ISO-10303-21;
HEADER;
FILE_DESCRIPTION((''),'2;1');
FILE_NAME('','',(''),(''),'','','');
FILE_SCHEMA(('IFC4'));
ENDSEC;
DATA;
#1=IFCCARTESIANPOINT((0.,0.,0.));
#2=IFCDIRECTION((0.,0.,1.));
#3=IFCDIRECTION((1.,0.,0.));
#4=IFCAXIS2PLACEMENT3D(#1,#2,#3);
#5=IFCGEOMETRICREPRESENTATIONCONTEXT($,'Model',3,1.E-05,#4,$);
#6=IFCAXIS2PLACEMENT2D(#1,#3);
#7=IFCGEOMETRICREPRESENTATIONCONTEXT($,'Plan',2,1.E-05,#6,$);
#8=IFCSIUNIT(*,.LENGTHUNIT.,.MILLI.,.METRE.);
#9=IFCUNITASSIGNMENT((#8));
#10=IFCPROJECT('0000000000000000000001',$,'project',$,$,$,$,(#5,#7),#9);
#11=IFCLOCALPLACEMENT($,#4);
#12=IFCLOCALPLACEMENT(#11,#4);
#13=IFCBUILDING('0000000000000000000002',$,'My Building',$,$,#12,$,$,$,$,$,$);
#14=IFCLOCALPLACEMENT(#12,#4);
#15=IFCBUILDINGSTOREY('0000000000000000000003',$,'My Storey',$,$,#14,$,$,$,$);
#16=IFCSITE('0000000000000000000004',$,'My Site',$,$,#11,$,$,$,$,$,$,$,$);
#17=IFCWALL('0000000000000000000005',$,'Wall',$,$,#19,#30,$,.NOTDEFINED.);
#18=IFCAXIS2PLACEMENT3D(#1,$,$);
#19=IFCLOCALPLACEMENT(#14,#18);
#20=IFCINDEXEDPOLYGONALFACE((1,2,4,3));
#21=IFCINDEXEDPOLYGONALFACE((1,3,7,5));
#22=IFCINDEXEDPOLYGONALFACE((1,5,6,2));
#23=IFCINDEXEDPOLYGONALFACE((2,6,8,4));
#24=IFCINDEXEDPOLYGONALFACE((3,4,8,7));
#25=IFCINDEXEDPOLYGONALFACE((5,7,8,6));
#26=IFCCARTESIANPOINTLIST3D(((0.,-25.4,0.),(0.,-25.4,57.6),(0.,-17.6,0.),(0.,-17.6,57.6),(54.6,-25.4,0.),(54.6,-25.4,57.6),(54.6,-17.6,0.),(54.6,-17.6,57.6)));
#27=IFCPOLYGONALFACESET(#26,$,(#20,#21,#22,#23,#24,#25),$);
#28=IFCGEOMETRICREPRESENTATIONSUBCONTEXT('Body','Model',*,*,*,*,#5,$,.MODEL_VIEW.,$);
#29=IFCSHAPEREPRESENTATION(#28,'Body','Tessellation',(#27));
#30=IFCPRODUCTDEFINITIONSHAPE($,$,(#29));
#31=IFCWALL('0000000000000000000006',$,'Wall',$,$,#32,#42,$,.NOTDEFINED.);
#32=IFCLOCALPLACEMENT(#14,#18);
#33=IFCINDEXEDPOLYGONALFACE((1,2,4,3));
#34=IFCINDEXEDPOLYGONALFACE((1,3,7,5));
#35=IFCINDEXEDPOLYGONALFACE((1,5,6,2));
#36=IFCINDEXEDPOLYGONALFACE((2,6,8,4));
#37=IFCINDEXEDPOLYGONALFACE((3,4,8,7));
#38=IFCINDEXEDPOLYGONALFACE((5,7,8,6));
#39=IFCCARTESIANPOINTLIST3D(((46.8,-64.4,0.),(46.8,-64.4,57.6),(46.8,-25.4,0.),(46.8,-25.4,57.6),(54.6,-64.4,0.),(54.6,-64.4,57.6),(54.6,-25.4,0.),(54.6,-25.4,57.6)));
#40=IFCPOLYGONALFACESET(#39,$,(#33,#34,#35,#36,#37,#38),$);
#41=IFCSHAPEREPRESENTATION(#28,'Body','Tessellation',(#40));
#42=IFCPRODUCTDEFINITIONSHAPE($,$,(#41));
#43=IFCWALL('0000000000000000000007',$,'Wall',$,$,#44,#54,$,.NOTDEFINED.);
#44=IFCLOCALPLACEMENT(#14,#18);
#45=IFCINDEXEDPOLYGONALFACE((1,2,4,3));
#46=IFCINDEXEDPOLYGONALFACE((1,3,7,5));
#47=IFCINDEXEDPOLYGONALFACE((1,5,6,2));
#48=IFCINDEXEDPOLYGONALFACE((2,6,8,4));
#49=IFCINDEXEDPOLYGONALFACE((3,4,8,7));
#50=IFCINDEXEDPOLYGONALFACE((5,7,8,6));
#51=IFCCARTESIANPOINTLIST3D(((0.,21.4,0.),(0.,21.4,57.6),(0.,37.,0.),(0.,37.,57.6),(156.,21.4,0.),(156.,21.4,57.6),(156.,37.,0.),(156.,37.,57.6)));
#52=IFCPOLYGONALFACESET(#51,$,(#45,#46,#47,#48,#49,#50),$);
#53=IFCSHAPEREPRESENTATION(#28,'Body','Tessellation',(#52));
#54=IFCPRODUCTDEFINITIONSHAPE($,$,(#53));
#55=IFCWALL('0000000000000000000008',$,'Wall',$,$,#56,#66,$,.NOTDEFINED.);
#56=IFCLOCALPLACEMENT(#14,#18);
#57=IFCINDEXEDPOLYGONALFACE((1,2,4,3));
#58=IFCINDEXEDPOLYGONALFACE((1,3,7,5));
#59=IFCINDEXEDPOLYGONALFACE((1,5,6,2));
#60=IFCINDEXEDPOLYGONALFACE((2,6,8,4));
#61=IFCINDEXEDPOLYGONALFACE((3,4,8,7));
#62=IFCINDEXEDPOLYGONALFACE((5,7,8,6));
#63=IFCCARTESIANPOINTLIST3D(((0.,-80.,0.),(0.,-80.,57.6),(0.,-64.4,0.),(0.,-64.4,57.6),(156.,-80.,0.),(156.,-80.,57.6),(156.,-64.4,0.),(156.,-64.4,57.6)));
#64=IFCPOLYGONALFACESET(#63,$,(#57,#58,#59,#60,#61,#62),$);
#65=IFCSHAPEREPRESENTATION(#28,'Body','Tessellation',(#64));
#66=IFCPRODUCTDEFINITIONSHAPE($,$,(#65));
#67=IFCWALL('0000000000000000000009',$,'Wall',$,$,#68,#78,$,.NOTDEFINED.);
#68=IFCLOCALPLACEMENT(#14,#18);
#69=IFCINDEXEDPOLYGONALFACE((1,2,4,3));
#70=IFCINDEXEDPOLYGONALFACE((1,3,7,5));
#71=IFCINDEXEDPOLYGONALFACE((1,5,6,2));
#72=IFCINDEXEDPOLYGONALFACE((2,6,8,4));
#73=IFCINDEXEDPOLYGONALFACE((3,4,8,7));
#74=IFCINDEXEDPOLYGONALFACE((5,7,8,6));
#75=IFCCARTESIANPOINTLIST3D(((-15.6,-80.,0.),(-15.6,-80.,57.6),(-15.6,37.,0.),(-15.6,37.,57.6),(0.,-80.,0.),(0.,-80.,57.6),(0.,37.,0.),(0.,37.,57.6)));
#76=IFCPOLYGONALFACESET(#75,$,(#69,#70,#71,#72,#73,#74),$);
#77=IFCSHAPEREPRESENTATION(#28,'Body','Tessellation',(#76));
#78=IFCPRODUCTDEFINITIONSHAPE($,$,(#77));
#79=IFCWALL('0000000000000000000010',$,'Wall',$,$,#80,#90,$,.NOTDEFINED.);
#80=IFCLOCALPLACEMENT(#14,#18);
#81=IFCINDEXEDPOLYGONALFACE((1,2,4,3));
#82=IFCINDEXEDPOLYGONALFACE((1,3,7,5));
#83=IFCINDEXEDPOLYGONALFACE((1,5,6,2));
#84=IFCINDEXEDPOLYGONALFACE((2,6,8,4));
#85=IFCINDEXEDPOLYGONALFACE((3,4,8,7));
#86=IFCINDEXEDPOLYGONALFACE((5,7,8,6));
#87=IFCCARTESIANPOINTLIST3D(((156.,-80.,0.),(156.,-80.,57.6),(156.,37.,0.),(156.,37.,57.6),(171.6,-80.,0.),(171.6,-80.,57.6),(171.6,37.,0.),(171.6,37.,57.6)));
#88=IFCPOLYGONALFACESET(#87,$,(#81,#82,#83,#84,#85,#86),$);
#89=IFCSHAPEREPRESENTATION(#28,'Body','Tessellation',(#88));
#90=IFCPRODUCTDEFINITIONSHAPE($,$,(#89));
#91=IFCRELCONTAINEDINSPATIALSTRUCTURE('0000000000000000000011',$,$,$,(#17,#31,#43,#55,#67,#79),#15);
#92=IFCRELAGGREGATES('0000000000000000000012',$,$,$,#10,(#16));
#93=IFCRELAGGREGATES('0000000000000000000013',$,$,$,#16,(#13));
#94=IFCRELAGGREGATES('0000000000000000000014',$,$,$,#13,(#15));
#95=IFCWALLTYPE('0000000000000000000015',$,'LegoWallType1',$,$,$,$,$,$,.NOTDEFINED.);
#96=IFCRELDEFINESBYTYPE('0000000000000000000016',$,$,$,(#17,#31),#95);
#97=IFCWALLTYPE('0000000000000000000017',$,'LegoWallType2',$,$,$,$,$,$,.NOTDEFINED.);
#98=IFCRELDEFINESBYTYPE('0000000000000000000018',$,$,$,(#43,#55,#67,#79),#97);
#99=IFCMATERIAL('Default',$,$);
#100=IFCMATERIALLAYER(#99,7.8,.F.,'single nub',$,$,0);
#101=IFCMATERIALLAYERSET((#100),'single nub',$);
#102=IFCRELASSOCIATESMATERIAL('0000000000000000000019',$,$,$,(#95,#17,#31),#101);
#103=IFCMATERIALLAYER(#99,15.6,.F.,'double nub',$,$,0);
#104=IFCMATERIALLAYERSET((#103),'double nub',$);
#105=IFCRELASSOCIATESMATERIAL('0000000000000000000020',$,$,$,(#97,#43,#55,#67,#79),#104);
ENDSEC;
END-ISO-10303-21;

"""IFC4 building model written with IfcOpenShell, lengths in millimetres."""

from ifc_helpers import new_model, si_unit, frame, frame_2d, origin_with_axes, place, context, subcontext, project, spatial, indexed_curve, outline, extrude, material, layer, layer_set, layer_usage, type_object, element, save


model = new_model("IFC4")

# Units and contexts
model_context = context("Model", 3, precision=1e-05, world=origin_with_axes())
plan_context = context("Plan", 2, precision=1e-05, world=frame_2d((0.0, 0.0, 0.0), x_axis=(1.0, 0.0, 0.0)))
body_context = subcontext(model_context, "Body", "Model", "MODEL_VIEW")
ifc_project = project(units=[si_unit("LENGTHUNIT", "METRE", prefix="MILLI")], contexts=[model_context, plan_context])

# Site, building, storey
site_placement = place(None, origin_with_axes())
site = spatial("IfcSite", under=ifc_project, at=site_placement, Name="My Site")
building_placement = place(site_placement, origin_with_axes())
building = spatial("IfcBuilding", under=site, at=building_placement, Name="My Building")
storey_placement = place(building_placement, origin_with_axes())
storey = spatial("IfcBuildingStorey", under=building, at=storey_placement, Name="My Storey")

# Walls
ifc_material = material(Name="Default")
ifc_layer_1 = layer(ifc_material, 7.8, ventilated=False, Name="single nub", Priority=0)
ifc_layer_set_1 = layer_set([ifc_layer_1], Name="single nub")
ifc_layer_usage_1 = layer_usage(ifc_layer_set_1, "AXIS2", "POSITIVE", 0.0)
wall_type_1 = type_object("IfcWallType", Name="LegoWallType1", PredefinedType="NOTDEFINED", material=ifc_layer_set_1)
wall_1_placement = place(storey_placement, frame((54.6, -17.6, 0.0), z_axis=(0.0, 0.0, 1.0), x_axis=(-1.0, 0.0, 0.0)))
element("IfcWall", 1, at=wall_1_placement, inside=storey, type_object=wall_type_1, material=ifc_layer_usage_1, Name="Wall", PredefinedType="NOTDEFINED", context=body_context, shape_type="SweptSolid", body=[
    extrude(outline(indexed_curve([(0.0, 0.0), (0.0, 7.8), (54.6, 7.8), (54.6, 0.0), (0.0, 0.0)], self_intersect=False)), origin_with_axes(), (0.0, 0.0, 1.0), 57.6),
])
ifc_layer_usage_2 = layer_usage(ifc_layer_set_1, "AXIS2", "POSITIVE", 0.0)
wall_2_placement = place(storey_placement, frame((46.8, -25.4, 0.0), z_axis=(0.0, 0.0, 1.0), x_axis=(0.0, -1.0, 0.0)))
element("IfcWall", 2, at=wall_2_placement, inside=storey, type_object=wall_type_1, material=ifc_layer_usage_2, Name="Wall", PredefinedType="NOTDEFINED", context=body_context, shape_type="SweptSolid", body=[
    extrude(outline(indexed_curve([(0.0, 0.0), (0.0, 7.8), (39.0, 7.8), (39.0, 0.0), (0.0, 0.0)], self_intersect=False)), origin_with_axes(), (0.0, 0.0, 1.0), 57.6),
])
ifc_layer_2 = layer(ifc_material, 15.6, ventilated=False, Name="double nub", Priority=0)
ifc_layer_set_2 = layer_set([ifc_layer_2], Name="double nub")
ifc_layer_usage_3 = layer_usage(ifc_layer_set_2, "AXIS2", "POSITIVE", 0.0)
wall_type_2 = type_object("IfcWallType", Name="LegoWallType2", PredefinedType="NOTDEFINED", material=ifc_layer_set_2)
wall_3_placement = place(storey_placement, frame((0.0, 21.4, 0.0), z_axis=(0.0, 0.0, 1.0), x_axis=(1.0, 0.0, 0.0)))
element("IfcWall", 3, at=wall_3_placement, inside=storey, type_object=wall_type_2, material=ifc_layer_usage_3, Name="Wall", PredefinedType="NOTDEFINED", context=body_context, shape_type="SweptSolid", body=[
    extrude(outline(indexed_curve([(0.0, 0.0), (0.0, 15.6), (156.0, 15.6), (156.0, 0.0), (0.0, 0.0)], self_intersect=False)), origin_with_axes(), (0.0, 0.0, 1.0), 57.6),
])
ifc_layer_usage_4 = layer_usage(ifc_layer_set_2, "AXIS2", "POSITIVE", 0.0)
wall_4_placement = place(storey_placement, frame((156.0, -64.4, 0.0), z_axis=(0.0, 0.0, 1.0), x_axis=(-1.0, 0.0, 0.0)))
element("IfcWall", 4, at=wall_4_placement, inside=storey, type_object=wall_type_2, material=ifc_layer_usage_4, Name="Wall", PredefinedType="NOTDEFINED", context=body_context, shape_type="SweptSolid", body=[
    extrude(outline(indexed_curve([(0.0, 0.0), (0.0, 15.6), (156.0, 15.6), (156.0, 0.0), (0.0, 0.0)], self_intersect=False)), origin_with_axes(), (0.0, 0.0, 1.0), 57.6),
])
ifc_layer_usage_5 = layer_usage(ifc_layer_set_2, "AXIS2", "POSITIVE", 0.0)
wall_5_placement = place(storey_placement, frame((-15.6, 37.0, 0.0), z_axis=(0.0, 0.0, 1.0), x_axis=(0.0, -1.0, 0.0)))
element("IfcWall", 5, at=wall_5_placement, inside=storey, type_object=wall_type_2, material=ifc_layer_usage_5, Name="Wall", PredefinedType="NOTDEFINED", context=body_context, shape_type="SweptSolid", body=[
    extrude(outline(indexed_curve([(0.0, 0.0), (0.0, 15.6), (117.0, 15.6), (117.0, 0.0), (0.0, 0.0)], self_intersect=False)), origin_with_axes(), (0.0, 0.0, 1.0), 57.6),
])
ifc_layer_usage_6 = layer_usage(ifc_layer_set_2, "AXIS2", "POSITIVE", 0.0)
wall_6_placement = place(storey_placement, frame((156.0, 37.0, 0.0), z_axis=(0.0, 0.0, 1.0), x_axis=(-0.000001, -1.0, 0.0)))
element("IfcWall", 6, at=wall_6_placement, inside=storey, type_object=wall_type_2, material=ifc_layer_usage_6, Name="Wall", PredefinedType="NOTDEFINED", context=body_context, shape_type="SweptSolid", body=[
    extrude(outline(indexed_curve([(0.0, 0.0), (0.0, 15.6), (117.0, 15.6), (117.0, 0.0), (0.0, 0.0)], self_intersect=False)), origin_with_axes(), (0.0, 0.0, 1.0), 57.6),
])

save(model, "model.ifc")
